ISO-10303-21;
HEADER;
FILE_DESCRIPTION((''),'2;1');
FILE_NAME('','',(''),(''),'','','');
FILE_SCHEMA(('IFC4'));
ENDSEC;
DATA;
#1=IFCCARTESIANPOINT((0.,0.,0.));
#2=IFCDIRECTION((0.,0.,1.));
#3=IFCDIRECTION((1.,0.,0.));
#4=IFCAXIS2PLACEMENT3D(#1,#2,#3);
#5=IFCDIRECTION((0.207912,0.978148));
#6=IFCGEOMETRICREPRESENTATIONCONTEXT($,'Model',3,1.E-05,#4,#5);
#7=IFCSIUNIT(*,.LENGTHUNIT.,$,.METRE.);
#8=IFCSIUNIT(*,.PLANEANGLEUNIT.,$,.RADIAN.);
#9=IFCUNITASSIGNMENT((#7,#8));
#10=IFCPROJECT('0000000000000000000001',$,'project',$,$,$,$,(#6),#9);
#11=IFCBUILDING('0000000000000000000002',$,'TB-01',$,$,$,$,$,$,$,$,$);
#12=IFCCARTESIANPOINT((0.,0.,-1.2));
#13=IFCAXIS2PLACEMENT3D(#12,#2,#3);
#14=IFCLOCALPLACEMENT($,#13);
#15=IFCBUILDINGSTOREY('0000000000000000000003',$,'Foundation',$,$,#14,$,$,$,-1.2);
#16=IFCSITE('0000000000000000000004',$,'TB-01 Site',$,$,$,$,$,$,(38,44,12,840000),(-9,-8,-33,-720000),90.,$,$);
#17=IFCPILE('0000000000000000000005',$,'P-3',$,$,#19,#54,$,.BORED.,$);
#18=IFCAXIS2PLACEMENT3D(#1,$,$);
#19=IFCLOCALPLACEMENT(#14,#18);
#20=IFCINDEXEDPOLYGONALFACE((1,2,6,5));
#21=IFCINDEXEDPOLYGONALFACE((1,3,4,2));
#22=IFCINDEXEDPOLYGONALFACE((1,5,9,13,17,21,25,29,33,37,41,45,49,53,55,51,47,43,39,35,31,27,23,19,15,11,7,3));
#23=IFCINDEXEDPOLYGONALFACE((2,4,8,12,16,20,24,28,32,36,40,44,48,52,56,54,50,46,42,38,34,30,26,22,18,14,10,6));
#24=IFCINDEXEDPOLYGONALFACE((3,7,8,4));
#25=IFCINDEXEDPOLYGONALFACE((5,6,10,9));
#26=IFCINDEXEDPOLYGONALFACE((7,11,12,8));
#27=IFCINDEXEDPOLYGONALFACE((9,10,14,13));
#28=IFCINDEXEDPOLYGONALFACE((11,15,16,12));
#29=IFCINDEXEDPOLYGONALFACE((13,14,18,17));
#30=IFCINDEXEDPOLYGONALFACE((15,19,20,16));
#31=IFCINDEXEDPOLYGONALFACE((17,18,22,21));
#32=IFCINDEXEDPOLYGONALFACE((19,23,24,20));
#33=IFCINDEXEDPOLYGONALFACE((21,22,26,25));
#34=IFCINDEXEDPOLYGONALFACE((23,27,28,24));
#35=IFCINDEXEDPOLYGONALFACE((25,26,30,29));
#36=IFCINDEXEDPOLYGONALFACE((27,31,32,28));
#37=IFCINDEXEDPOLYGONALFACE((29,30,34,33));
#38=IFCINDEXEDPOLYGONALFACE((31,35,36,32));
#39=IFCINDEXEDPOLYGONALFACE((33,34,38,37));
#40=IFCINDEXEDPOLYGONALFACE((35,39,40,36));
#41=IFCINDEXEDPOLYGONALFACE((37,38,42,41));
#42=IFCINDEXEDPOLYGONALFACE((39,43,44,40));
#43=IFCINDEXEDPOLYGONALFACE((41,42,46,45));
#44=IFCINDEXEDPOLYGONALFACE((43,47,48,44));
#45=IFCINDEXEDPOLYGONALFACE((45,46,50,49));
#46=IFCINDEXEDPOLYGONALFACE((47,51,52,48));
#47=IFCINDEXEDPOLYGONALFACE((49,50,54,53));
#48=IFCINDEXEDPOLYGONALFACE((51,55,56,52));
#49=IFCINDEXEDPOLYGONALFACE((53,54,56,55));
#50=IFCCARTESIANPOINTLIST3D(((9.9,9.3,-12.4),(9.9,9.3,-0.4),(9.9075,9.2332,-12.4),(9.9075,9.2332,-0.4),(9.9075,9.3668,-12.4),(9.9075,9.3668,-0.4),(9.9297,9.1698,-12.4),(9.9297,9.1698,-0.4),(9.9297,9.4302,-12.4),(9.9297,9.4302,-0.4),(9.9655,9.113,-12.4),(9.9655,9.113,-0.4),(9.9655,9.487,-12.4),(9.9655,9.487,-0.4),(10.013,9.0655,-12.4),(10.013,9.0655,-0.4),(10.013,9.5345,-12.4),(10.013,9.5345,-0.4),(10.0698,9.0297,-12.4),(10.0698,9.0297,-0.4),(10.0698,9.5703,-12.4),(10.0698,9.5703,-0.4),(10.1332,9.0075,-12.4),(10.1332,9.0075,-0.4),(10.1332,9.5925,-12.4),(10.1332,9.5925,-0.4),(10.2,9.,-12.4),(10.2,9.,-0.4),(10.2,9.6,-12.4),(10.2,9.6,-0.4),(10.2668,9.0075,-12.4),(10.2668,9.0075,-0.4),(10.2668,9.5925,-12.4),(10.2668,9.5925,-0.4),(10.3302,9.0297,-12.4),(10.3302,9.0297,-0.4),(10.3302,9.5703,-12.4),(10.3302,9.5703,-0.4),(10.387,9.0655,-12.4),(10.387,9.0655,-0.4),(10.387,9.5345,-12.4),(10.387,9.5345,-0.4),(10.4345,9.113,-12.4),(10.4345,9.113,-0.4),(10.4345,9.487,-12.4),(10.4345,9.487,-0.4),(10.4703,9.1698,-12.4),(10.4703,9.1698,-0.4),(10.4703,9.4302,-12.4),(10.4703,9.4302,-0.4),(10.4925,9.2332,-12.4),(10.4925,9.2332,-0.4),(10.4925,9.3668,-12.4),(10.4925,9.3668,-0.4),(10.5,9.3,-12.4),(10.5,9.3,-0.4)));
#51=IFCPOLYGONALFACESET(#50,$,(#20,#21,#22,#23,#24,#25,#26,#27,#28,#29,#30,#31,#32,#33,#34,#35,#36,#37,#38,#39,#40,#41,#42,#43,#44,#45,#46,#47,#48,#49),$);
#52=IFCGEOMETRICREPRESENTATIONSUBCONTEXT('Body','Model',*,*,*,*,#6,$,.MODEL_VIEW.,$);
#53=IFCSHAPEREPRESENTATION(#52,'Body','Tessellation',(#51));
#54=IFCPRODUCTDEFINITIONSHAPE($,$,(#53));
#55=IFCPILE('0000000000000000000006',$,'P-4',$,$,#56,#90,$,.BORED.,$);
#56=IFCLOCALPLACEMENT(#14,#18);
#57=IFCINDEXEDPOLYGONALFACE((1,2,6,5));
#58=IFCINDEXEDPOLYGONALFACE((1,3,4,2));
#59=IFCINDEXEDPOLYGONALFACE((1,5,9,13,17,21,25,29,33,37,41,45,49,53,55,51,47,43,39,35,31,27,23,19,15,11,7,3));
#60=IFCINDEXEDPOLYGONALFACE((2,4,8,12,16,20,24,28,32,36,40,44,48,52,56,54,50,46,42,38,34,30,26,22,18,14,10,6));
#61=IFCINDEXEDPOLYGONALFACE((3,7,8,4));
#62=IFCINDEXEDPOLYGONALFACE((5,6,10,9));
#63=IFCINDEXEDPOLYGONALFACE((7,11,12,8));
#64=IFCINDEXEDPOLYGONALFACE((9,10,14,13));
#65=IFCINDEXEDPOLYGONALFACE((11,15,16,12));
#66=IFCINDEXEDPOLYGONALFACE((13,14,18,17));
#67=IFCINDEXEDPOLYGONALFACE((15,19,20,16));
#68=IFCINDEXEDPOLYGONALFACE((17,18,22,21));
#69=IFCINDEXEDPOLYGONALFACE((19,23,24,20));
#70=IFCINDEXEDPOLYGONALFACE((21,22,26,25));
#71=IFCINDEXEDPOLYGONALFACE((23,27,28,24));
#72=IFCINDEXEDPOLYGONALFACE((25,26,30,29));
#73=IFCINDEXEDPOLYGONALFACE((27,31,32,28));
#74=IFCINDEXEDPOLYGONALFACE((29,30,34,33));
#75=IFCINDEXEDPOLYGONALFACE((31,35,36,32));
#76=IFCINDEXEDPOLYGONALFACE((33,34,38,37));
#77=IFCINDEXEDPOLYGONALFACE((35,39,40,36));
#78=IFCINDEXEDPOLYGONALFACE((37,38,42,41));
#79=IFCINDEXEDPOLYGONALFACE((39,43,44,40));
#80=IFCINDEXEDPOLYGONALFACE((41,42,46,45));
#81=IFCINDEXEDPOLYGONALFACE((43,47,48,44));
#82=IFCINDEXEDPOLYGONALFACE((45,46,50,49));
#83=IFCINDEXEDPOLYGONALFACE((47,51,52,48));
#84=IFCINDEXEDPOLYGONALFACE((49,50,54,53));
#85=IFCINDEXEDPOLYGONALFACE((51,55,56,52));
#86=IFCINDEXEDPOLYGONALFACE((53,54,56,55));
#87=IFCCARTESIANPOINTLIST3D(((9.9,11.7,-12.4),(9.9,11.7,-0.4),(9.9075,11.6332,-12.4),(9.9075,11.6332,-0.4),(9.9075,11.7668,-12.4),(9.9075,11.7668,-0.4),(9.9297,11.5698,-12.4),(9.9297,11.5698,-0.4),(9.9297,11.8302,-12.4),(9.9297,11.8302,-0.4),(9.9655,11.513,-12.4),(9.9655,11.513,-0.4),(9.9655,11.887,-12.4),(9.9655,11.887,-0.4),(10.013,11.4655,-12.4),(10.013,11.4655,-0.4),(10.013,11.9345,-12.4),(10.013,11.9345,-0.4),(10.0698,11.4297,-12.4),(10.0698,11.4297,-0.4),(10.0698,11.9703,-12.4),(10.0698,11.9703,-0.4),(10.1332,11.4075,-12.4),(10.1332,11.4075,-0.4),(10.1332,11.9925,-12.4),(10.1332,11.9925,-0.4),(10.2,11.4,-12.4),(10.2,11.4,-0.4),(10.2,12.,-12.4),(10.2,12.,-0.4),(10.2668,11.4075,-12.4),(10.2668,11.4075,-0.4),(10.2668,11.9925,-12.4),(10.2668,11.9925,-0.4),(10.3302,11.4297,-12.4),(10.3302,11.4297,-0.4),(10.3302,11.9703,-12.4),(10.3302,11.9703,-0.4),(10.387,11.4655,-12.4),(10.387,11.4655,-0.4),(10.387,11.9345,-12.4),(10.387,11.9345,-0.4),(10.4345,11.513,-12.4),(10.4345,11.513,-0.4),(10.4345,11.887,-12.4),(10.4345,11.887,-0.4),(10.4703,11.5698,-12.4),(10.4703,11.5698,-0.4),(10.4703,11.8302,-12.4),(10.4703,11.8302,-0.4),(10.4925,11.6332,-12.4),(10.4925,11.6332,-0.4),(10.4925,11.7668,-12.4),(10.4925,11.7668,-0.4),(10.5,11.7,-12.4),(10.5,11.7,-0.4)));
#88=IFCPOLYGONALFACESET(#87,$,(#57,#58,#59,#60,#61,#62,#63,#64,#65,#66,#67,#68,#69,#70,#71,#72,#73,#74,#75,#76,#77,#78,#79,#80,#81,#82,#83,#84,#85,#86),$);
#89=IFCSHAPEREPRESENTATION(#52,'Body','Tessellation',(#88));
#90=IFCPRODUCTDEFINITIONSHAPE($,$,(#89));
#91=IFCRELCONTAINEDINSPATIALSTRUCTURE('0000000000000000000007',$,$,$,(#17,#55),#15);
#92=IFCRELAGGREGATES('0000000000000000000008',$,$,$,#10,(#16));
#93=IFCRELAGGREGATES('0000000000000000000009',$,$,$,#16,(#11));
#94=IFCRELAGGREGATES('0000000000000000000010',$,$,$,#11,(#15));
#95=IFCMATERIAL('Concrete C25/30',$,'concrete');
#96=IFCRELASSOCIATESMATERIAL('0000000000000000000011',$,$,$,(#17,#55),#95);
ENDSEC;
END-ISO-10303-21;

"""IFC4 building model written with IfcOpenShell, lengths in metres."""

from ifc_helpers import new_model, si_unit, direction, frame, origin_with_axes, place, context, subcontext, project, spatial, circle, extrude, material, element, save


model = new_model("IFC4")

# Units and contexts
model_context = context("Model", 3, precision=1e-05, world=origin_with_axes(), true_north=direction((0.207912, 0.978148)))
body_context = subcontext(model_context, "Body", "Model", "MODEL_VIEW")
ifc_project = project(units=[si_unit("LENGTHUNIT", "METRE"), si_unit("PLANEANGLEUNIT", "RADIAN")], contexts=[model_context])

# Site, building, storey
site = spatial("IfcSite", under=ifc_project, Name="TB-01 Site", RefLatitude=(38, 44, 12, 840000), RefLongitude=(-9, -8, -33, -720000), RefElevation=90.0)
building = spatial("IfcBuilding", under=site, Name="TB-01")
storey_placement = place(None, frame((0.0, 0.0, -1.2), z_axis=(0.0, 0.0, 1.0), x_axis=(1.0, 0.0, 0.0)))
storey = spatial("IfcBuildingStorey", under=building, at=storey_placement, Name="Foundation", Elevation=-1.2)

# Shared definitions
ifc_material_1 = material(Name="Concrete C25/30", Category="concrete")

# Piles
for number, where, z_axis, x_axis, name in (
    (1, (10.2, 9.3, -12.4), (0.0, 0.0, 1.0), (1.0, 0.0, 0.0), "P-3"),
    (2, (10.2, 11.7, -12.4), (0.0, 0.0, 1.0), (1.0, 0.0, 0.0), "P-4"),
):
    element("IfcPile", number, at=place(storey_placement, frame(where, z_axis=z_axis, x_axis=x_axis)), inside=storey, material=ifc_material_1, Name=name, PredefinedType="BORED", context=body_context, shape_type="SweptSolid", body=[
        extrude(circle(Radius=0.3), origin_with_axes(), (0.0, 0.0, 1.0), 12.0),
    ])

save(model, "model.ifc")
